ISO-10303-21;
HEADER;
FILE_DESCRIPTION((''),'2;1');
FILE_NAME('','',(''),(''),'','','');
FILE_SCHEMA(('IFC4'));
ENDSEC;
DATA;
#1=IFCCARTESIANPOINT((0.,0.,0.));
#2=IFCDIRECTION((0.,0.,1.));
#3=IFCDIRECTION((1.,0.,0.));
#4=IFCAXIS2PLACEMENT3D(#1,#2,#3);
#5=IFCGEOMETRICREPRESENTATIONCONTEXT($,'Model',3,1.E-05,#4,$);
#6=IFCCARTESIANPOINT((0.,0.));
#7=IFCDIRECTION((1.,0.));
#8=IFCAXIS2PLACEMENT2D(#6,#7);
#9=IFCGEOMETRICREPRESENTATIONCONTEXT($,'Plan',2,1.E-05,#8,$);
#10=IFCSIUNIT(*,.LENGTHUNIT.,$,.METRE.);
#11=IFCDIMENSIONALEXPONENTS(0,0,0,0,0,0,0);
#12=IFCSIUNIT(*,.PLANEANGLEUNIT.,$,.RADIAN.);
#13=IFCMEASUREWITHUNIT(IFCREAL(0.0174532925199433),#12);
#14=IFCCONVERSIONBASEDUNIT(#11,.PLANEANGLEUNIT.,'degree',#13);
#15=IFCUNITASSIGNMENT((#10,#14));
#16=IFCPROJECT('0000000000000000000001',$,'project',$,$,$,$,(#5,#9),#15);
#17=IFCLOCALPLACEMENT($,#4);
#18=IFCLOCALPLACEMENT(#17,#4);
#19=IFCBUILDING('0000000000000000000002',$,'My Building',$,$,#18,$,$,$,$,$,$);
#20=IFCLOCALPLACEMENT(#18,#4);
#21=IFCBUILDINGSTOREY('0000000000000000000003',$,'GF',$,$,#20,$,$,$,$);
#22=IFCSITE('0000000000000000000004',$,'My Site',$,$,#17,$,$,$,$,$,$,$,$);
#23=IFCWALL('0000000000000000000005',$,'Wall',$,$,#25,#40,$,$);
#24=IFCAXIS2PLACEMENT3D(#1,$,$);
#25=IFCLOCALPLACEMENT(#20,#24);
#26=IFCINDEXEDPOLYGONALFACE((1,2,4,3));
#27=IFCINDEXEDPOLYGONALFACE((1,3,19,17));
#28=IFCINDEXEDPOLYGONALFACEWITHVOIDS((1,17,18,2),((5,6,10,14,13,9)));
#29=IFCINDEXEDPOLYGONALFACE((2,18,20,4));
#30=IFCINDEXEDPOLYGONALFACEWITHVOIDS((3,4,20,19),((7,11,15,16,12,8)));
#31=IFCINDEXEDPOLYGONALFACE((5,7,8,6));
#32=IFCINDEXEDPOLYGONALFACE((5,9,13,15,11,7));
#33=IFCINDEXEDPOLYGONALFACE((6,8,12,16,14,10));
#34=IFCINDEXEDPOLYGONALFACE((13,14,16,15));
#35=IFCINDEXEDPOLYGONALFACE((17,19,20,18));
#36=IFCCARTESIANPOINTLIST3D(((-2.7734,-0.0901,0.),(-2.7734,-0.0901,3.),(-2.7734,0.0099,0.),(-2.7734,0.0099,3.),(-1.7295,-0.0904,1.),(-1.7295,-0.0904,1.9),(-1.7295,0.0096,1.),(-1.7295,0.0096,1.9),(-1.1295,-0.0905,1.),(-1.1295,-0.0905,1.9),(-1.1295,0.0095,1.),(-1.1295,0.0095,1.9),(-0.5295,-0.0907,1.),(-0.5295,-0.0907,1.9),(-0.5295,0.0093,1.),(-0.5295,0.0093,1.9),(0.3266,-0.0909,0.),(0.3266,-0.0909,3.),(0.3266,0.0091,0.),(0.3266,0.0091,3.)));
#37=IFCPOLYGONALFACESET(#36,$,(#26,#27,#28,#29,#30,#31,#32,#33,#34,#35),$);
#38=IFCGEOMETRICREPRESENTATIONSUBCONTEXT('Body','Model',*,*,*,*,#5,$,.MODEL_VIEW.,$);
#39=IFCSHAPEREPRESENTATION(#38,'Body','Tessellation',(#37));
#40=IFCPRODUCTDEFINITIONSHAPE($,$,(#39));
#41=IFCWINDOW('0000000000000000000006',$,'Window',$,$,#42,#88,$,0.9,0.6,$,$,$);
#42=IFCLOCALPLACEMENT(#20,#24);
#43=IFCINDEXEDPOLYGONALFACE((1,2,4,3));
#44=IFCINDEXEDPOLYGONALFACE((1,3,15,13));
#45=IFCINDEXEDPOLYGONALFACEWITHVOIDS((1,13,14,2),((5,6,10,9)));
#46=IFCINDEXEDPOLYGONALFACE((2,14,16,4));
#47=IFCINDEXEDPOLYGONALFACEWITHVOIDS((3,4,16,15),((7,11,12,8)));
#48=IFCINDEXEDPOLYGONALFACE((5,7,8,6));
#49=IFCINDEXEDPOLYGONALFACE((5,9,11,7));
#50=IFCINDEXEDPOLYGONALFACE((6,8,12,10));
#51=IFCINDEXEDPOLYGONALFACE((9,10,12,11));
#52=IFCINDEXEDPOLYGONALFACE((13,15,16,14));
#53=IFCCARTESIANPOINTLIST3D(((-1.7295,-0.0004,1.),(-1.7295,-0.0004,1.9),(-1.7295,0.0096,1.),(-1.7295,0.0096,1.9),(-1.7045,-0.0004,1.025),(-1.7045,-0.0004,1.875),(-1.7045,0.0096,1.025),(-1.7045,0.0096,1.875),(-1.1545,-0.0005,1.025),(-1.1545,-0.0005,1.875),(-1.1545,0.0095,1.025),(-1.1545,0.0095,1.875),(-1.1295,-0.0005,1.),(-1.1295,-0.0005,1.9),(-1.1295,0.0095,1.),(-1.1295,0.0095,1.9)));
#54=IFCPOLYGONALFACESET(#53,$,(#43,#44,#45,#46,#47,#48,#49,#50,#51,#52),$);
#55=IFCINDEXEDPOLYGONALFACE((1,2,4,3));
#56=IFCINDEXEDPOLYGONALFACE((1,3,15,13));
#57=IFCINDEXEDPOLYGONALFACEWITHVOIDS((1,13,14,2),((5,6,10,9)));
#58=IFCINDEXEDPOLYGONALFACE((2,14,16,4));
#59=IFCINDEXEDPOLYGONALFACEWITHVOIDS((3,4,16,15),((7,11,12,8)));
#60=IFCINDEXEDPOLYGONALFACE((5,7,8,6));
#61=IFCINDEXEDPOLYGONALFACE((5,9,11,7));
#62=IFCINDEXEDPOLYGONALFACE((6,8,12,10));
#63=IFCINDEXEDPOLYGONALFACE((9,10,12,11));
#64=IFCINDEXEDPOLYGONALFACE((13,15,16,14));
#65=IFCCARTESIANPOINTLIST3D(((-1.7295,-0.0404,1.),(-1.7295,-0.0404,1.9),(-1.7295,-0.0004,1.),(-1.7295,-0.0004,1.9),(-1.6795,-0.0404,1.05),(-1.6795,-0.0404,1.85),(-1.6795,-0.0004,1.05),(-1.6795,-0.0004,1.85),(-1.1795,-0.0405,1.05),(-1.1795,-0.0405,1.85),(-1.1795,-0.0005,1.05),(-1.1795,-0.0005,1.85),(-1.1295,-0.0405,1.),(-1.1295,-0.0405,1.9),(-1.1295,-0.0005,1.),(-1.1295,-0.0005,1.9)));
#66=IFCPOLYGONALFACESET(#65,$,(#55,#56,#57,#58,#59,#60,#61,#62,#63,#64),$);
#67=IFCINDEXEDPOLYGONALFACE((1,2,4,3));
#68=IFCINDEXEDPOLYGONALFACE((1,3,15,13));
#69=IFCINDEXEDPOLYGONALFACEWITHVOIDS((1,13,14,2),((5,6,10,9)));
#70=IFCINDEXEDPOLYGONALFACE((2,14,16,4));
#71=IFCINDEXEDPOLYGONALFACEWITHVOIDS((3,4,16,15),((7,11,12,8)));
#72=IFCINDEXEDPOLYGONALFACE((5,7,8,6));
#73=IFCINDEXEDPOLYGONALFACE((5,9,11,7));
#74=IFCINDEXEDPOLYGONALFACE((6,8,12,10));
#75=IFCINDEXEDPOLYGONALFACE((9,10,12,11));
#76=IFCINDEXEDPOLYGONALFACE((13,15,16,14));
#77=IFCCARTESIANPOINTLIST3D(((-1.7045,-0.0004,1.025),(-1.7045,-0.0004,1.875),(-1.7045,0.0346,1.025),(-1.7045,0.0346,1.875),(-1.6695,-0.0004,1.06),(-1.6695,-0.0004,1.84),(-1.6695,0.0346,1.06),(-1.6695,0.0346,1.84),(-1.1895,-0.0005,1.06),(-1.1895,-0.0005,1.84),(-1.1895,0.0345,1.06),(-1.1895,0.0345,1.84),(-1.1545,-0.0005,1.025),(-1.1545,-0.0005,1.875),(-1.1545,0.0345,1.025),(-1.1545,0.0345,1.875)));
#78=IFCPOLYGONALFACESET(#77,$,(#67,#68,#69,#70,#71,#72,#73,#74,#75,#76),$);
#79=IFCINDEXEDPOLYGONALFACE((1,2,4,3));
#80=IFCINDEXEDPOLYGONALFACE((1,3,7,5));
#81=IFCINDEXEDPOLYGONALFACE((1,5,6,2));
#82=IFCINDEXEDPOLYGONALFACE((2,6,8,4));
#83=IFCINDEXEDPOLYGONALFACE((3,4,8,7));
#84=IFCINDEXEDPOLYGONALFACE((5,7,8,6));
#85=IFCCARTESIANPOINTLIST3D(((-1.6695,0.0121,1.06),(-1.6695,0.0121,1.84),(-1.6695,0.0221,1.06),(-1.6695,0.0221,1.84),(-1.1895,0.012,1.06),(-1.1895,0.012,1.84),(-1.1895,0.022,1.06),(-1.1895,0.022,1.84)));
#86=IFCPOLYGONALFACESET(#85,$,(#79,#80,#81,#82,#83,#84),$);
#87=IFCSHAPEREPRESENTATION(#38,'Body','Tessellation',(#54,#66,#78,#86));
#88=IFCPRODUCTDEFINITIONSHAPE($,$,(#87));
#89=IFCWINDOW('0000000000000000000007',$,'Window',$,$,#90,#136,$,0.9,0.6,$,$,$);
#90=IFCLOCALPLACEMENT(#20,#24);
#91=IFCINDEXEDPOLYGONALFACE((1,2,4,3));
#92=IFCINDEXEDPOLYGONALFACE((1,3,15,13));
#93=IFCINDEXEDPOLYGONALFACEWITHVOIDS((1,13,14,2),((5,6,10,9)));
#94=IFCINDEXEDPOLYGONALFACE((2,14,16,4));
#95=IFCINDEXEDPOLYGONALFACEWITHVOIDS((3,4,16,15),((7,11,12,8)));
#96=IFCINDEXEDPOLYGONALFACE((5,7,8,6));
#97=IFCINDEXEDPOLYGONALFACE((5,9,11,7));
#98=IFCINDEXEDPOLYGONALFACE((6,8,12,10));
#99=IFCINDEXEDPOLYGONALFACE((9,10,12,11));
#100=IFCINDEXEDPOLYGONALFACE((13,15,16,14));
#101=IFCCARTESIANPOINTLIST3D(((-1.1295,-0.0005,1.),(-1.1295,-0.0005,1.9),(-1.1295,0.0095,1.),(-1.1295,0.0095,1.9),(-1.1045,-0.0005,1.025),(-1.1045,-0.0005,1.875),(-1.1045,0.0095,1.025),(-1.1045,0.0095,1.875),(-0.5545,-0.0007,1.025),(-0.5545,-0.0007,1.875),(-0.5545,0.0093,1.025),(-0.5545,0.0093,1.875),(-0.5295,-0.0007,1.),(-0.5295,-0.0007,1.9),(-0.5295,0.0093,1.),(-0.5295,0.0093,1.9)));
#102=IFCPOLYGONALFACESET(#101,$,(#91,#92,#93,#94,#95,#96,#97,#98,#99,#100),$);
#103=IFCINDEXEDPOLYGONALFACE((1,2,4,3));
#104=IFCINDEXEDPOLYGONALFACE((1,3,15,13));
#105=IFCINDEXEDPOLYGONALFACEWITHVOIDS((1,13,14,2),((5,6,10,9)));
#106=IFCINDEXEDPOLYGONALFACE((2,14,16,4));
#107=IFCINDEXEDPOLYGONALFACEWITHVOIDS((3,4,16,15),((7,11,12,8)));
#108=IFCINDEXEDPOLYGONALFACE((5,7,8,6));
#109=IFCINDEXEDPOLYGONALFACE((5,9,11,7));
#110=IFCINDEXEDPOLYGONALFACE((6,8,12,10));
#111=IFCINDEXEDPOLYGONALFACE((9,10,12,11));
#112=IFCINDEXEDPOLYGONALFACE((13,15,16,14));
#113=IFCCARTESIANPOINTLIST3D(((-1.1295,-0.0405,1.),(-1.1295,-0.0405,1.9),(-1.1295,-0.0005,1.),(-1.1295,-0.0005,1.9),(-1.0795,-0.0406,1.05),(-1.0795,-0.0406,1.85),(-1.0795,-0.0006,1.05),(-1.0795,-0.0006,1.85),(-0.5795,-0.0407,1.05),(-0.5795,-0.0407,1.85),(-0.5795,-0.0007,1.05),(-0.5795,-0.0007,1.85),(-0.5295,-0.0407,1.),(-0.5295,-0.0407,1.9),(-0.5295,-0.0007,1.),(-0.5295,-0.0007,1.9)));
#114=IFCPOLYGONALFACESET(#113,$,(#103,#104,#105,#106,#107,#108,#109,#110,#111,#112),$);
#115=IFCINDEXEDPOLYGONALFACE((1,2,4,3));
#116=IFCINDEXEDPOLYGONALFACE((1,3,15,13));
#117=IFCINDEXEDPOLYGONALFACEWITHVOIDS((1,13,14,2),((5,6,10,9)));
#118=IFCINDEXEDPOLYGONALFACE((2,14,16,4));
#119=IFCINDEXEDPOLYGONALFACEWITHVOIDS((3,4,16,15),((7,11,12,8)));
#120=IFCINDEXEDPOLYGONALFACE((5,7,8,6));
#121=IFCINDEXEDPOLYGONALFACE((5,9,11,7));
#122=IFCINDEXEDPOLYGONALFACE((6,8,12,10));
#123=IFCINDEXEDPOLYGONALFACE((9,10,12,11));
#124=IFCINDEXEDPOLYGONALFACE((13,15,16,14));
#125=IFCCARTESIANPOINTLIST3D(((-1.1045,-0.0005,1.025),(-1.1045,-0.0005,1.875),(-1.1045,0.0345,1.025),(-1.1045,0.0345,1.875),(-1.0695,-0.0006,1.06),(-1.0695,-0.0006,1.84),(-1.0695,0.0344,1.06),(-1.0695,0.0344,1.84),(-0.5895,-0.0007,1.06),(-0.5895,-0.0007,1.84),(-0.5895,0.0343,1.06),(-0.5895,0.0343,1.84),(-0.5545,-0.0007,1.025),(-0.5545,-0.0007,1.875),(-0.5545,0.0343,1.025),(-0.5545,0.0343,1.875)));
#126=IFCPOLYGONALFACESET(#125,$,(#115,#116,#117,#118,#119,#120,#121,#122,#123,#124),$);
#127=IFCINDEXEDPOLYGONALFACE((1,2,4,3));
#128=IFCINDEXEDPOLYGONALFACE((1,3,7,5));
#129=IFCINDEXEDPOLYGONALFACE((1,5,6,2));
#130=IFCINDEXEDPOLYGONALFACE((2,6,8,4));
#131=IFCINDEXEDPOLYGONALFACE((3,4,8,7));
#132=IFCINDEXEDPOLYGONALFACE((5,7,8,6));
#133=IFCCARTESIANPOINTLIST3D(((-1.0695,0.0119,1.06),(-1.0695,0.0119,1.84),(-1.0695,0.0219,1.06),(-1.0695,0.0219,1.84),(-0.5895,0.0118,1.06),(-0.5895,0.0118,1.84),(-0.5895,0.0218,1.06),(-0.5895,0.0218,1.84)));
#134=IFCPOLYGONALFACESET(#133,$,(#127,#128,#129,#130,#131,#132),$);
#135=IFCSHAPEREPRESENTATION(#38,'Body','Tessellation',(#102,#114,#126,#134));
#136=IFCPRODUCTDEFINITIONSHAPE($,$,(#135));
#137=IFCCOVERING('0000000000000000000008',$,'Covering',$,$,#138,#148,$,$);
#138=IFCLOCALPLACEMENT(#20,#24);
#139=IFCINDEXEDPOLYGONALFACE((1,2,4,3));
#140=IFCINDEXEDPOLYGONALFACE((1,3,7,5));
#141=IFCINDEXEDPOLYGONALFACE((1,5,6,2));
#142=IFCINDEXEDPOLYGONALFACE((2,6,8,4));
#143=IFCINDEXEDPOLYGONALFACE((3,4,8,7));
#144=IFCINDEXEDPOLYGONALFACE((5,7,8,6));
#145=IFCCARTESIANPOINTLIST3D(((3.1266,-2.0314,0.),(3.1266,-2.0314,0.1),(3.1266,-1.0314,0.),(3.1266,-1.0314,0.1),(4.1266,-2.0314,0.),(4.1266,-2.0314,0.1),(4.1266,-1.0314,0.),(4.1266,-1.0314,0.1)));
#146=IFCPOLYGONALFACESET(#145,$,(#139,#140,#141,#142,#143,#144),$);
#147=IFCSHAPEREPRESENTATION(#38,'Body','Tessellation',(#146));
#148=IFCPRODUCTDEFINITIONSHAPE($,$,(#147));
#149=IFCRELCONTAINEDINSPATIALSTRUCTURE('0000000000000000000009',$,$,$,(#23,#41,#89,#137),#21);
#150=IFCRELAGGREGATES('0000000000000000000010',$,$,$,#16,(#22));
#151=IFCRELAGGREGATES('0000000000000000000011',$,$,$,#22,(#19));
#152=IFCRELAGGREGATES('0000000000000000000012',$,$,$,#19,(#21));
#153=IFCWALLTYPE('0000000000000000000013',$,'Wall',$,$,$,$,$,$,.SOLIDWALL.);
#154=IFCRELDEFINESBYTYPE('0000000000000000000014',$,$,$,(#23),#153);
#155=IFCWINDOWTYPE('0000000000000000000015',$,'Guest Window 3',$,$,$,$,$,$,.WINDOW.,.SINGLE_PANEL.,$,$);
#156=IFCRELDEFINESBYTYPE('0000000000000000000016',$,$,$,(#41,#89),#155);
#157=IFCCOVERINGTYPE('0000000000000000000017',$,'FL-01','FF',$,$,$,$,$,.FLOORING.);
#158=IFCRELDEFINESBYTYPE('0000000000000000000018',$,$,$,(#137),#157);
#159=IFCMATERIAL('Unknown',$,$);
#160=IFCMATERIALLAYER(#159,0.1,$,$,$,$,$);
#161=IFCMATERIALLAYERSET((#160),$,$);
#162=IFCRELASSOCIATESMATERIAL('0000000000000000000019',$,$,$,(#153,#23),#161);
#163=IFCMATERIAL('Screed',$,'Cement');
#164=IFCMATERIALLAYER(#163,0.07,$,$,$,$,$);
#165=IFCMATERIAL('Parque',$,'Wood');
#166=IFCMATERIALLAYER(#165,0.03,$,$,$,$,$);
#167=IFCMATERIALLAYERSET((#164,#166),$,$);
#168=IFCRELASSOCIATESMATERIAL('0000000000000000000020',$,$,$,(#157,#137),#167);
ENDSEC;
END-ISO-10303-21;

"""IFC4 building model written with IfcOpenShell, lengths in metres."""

from ifc_helpers import new_model, entity, si_unit, converted_unit, frame, origin_with_axes, origin_2d_with_axis, place, context, subcontext, project, spatial, line, indexed_curve, outline, extrude, shape, source, transform, mapped, material, layer, layer_set, layer_usage, type_object, type_shapes, element, fill, save


model = new_model("IFC4")

# Units and contexts
model_context = context("Model", 3, precision=1e-05, world=origin_with_axes())
plan_context = context("Plan", 2, precision=1e-05, world=origin_2d_with_axis())
body_context_1 = subcontext(model_context, "Body", "Model", "MODEL_VIEW")
body_context_2 = subcontext(plan_context, "Body", "Plan", "PLAN_VIEW")
ifc_project = project(units=[si_unit("LENGTHUNIT", "METRE"), converted_unit("PLANEANGLEUNIT", "degree", entity("IfcReal", 0.0174532925199433), si_unit("PLANEANGLEUNIT", "RADIAN"), dimensions=[0, 0, 0, 0, 0, 0, 0])], contexts=[model_context, plan_context])

# Site, building, storey
site_placement = place(None, origin_with_axes())
site = spatial("IfcSite", under=ifc_project, at=site_placement, Name="My Site")
building_placement = place(site_placement, origin_with_axes())
building = spatial("IfcBuilding", under=site, at=building_placement, Name="My Building")
storey_placement = place(building_placement, origin_with_axes())
storey = spatial("IfcBuildingStorey", under=building, at=storey_placement, Name="GF")

# Shared definitions
ifc_material_1 = material(Name="Unknown")

# Shared definitions
ifc_layer_1 = layer(ifc_material_1, 0.1)
ifc_layer_set_1 = layer_set([ifc_layer_1])
wall_type = type_object("IfcWallType", Name="Wall", PredefinedType="SOLIDWALL", material=ifc_layer_set_1)

# Wall, openings, windows
ifc_layer_usage_1 = layer_usage(ifc_layer_set_1, "AXIS2", "POSITIVE", 0.0)
wall_1_placement = place(storey_placement, frame((-2.7734, -0.0901, 0.0), z_axis=(0.0, 0.0, 1.0), x_axis=(1.0, -0.000264, 0.0)))
wall_1 = element("IfcWall", 1, at=wall_1_placement, inside=storey, type_object=wall_type, material=ifc_layer_usage_1, Name="Wall", context=body_context_1, shape_type="SweptSolid", body=[
    extrude(outline(indexed_curve([(0.0, 0.0), (0.0, 0.1), (3.1, 0.1), (3.1, 0.0)], segments=[line(1, 2, 3, 4, 1)])), origin_with_axes(), (0.0, 0.0, 1.0), 3.0),
])
shared_shape_1 = source(origin_with_axes(), body_context_1, "Body", "SweptSolid", [
    extrude(outline(indexed_curve([(0.0, 0.0), (0.6, 0.0), (0.6, 0.9), (0.0, 0.9)], segments=[line(1, 2, 3, 4, 1)])), frame((0.0, -0.6, 0.0), z_axis=(0.0, -1.0, 0.0), x_axis=(1.0, 0.0, 0.0)), (0.0, 0.0, -1.0), 1.2),
])
opening_1_placement = place(wall_1_placement, frame((1.0439, 0.0, 1.0), z_axis=(0.0, 0.0, 1.0), x_axis=(1.0, 0.0, 0.0)))
opening_1 = element("IfcOpeningElement", 2, at=opening_1_placement, cuts=wall_1, PredefinedType="OPENING", context=body_context_1, shape_type="MappedRepresentation", body=[
    mapped(shared_shape_1, transform((0.0, 0.0, 0.0), x_axis=(1.0, 0.0, 0.0), y_axis=(0.0, 1.0, 0.0), z_axis=(0.0, 0.0, 1.0), scale=1.0)),
])
opening_2_placement = place(wall_1_placement, frame((1.6439, 0.0, 1.0), z_axis=(0.0, 0.0, 1.0), x_axis=(1.0, 0.0, 0.0)))
opening_2 = element("IfcOpeningElement", 3, at=opening_2_placement, cuts=wall_1, PredefinedType="OPENING", context=body_context_1, shape_type="MappedRepresentation", body=[
    mapped(shared_shape_1, transform((0.0, 0.0, 0.0), x_axis=(1.0, 0.0, 0.0), y_axis=(0.0, 1.0, 0.0), z_axis=(0.0, 0.0, 1.0), scale=1.0)),
])
window_type_1 = type_object("IfcWindowType", Name="Guest Window 3", PartitioningType="SINGLE_PANEL", PredefinedType="WINDOW")
shared_shape_2 = source(origin_with_axes(), body_context_1, "Body", "SweptSolid", [
    extrude(outline(indexed_curve([(0.0, 0.0), (0.6, 0.0), (0.6, 0.9), (0.0, 0.9)], segments=[line(1, 2, 3, 4, 1)]), holes=[indexed_curve([(0.025, 0.025), (0.575, 0.025), (0.575, 0.875), (0.025, 0.875)], segments=[line(1, 2, 3, 4, 1)])]), frame((0.0, 0.09, 0.0), z_axis=(0.0, -1.0, 0.0), x_axis=(1.0, 0.0, 0.0)), (0.0, 0.0, -1.0), 0.01),
    extrude(outline(indexed_curve([(0.0, 0.0), (0.6, 0.0), (0.6, 0.9), (0.0, 0.9)], segments=[line(1, 2, 3, 4, 1)]), holes=[indexed_curve([(0.05, 0.05), (0.55, 0.05), (0.55, 0.85), (0.05, 0.85)], segments=[line(1, 2, 3, 4, 1)])]), frame((0.0, 0.05, 0.0), z_axis=(0.0, -1.0, 0.0), x_axis=(1.0, 0.0, 0.0)), (0.0, 0.0, -1.0), 0.04),
    extrude(outline(indexed_curve([(0.0, 0.0), (0.55, 0.0), (0.55, 0.85), (0.0, 0.85)], segments=[line(1, 2, 3, 4, 1)]), holes=[indexed_curve([(0.035, 0.035), (0.515, 0.035), (0.515, 0.815), (0.035, 0.815)], segments=[line(1, 2, 3, 4, 1)])]), frame((0.025, 0.09, 0.025), z_axis=(0.0, -1.0, 0.0), x_axis=(1.0, 0.0, 0.0)), (0.0, 0.0, -1.0), 0.035),
    extrude(outline(indexed_curve([(0.035, 0.035), (0.515, 0.035), (0.515, 0.815), (0.035, 0.815)], segments=[line(1, 2, 3, 4, 1)])), frame((0.025, 0.1025, 0.025), z_axis=(0.0, -1.0, 0.0), x_axis=(1.0, 0.0, 0.0)), (0.0, 0.0, -1.0), 0.01),
])
shared_shape_3 = source(origin_with_axes(), body_context_2, "Body", "Curve2D", [
    entity("IfcIndexedPolyCurve", entity("IfcCartesianPointList2D", [[0.05, 0.05], [0.55, 0.05]])),
    entity("IfcIndexedPolyCurve", entity("IfcCartesianPointList2D", [[0.0, 0.1], [0.025, 0.1], [0.025, 0.09], [0.05, 0.09], [0.05, 0.05], [0.0, 0.05]]), [entity("IfcLineIndex", [1, 2, 3, 4, 5, 6, 1])]),
    entity("IfcIndexedPolyCurve", entity("IfcCartesianPointList2D", [[0.6, 0.1], [0.575, 0.1], [0.575, 0.09], [0.55, 0.09], [0.55, 0.05], [0.6, 0.05]]), [entity("IfcLineIndex", [1, 2, 3, 4, 5, 6, 1])]),
    entity("IfcIndexedPolyCurve", entity("IfcCartesianPointList2D", [[0.025, 0.09], [0.06, 0.09], [0.06, 0.125], [0.025, 0.125]]), [entity("IfcLineIndex", [1, 2, 3, 4, 1])]),
    entity("IfcIndexedPolyCurve", entity("IfcCartesianPointList2D", [[0.575, 0.09], [0.54, 0.09], [0.54, 0.125], [0.575, 0.125]]), [entity("IfcLineIndex", [1, 2, 3, 4, 1])]),
    entity("IfcIndexedPolyCurve", entity("IfcCartesianPointList2D", [[0.06, 0.09], [0.54, 0.09]])),
    entity("IfcIndexedPolyCurve", entity("IfcCartesianPointList2D", [[0.06, 0.125], [0.54, 0.125]])),
    entity("IfcIndexedPolyCurve", entity("IfcCartesianPointList2D", [[0.06, 0.1075], [0.54, 0.1075]])),
])
type_shapes(window_type_1, [shared_shape_2, shared_shape_3])
window_1_placement = place(opening_1_placement, frame((0.0, 0.0, 0.0), z_axis=(0.0, 0.0, 1.0), x_axis=(1.0, 0.0, 0.0)))
window_1 = element("IfcWindow", 4, at=window_1_placement, inside=storey, type_object=window_type_1, Name="Window", OverallHeight=0.9, OverallWidth=0.6, shapes=[
    shape(body_context_1, "Body", "MappedRepresentation", [mapped(shared_shape_2, transform((0.0, 0.0, 0.0), x_axis=(1.0, 0.0, 0.0), y_axis=(0.0, 1.0, 0.0), z_axis=(0.0, 0.0, 1.0), scale=1.0))]),
    shape(body_context_2, "Body", "MappedRepresentation", [mapped(shared_shape_3, transform((0.0, 0.0, 0.0), x_axis=(1.0, 0.0, 0.0), y_axis=(0.0, 1.0, 0.0), z_axis=(0.0, 0.0, 1.0), scale=1.0))]),
])
fill(opening_1, window_1)
window_2_placement = place(opening_2_placement, frame((0.0, 0.0, 0.0), z_axis=(0.0, 0.0, 1.0), x_axis=(1.0, 0.0, 0.0)))
window_2 = element("IfcWindow", 5, at=window_2_placement, inside=storey, type_object=window_type_1, Name="Window", OverallHeight=0.9, OverallWidth=0.6, shapes=[
    shape(body_context_1, "Body", "MappedRepresentation", [mapped(shared_shape_2, transform((0.0, 0.0, 0.0), x_axis=(1.0, 0.0, 0.0), y_axis=(0.0, 1.0, 0.0), z_axis=(0.0, 0.0, 1.0), scale=1.0))]),
    shape(body_context_2, "Body", "MappedRepresentation", [mapped(shared_shape_3, transform((0.0, 0.0, 0.0), x_axis=(1.0, 0.0, 0.0), y_axis=(0.0, 1.0, 0.0), z_axis=(0.0, 0.0, 1.0), scale=1.0))]),
])
fill(opening_2, window_2)

# Covering
ifc_material_2 = material(Name="Screed", Category="Cement")
ifc_layer_2 = layer(ifc_material_2, 0.07)
ifc_material_3 = material(Name="Parque", Category="Wood")
ifc_layer_3 = layer(ifc_material_3, 0.03)
ifc_layer_set_2 = layer_set([ifc_layer_2, ifc_layer_3])
ifc_layer_usage_2 = layer_usage(ifc_layer_set_2, "AXIS3", "POSITIVE", 0.0)
covering_type = type_object("IfcCoveringType", Name="FL-01", Description="FF", PredefinedType="FLOORING", material=ifc_layer_set_2)
covering_placement = place(storey_placement, frame((3.1266, -2.0314, 0.0), z_axis=(0.0, 0.0, 1.0), x_axis=(1.0, 0.0, 0.0)))
element("IfcCovering", 6, at=covering_placement, inside=storey, type_object=covering_type, material=ifc_layer_usage_2, Name="Covering", context=body_context_1, shape_type="SweptSolid", body=[
    extrude(outline(indexed_curve([(0.0, 0.0), (1.0, 0.0), (1.0, 1.0), (0.0, 1.0), (0.0, 0.0)])), None, (0.0, 0.0, 1.0), 0.1),
])

save(model, "model.ifc")
